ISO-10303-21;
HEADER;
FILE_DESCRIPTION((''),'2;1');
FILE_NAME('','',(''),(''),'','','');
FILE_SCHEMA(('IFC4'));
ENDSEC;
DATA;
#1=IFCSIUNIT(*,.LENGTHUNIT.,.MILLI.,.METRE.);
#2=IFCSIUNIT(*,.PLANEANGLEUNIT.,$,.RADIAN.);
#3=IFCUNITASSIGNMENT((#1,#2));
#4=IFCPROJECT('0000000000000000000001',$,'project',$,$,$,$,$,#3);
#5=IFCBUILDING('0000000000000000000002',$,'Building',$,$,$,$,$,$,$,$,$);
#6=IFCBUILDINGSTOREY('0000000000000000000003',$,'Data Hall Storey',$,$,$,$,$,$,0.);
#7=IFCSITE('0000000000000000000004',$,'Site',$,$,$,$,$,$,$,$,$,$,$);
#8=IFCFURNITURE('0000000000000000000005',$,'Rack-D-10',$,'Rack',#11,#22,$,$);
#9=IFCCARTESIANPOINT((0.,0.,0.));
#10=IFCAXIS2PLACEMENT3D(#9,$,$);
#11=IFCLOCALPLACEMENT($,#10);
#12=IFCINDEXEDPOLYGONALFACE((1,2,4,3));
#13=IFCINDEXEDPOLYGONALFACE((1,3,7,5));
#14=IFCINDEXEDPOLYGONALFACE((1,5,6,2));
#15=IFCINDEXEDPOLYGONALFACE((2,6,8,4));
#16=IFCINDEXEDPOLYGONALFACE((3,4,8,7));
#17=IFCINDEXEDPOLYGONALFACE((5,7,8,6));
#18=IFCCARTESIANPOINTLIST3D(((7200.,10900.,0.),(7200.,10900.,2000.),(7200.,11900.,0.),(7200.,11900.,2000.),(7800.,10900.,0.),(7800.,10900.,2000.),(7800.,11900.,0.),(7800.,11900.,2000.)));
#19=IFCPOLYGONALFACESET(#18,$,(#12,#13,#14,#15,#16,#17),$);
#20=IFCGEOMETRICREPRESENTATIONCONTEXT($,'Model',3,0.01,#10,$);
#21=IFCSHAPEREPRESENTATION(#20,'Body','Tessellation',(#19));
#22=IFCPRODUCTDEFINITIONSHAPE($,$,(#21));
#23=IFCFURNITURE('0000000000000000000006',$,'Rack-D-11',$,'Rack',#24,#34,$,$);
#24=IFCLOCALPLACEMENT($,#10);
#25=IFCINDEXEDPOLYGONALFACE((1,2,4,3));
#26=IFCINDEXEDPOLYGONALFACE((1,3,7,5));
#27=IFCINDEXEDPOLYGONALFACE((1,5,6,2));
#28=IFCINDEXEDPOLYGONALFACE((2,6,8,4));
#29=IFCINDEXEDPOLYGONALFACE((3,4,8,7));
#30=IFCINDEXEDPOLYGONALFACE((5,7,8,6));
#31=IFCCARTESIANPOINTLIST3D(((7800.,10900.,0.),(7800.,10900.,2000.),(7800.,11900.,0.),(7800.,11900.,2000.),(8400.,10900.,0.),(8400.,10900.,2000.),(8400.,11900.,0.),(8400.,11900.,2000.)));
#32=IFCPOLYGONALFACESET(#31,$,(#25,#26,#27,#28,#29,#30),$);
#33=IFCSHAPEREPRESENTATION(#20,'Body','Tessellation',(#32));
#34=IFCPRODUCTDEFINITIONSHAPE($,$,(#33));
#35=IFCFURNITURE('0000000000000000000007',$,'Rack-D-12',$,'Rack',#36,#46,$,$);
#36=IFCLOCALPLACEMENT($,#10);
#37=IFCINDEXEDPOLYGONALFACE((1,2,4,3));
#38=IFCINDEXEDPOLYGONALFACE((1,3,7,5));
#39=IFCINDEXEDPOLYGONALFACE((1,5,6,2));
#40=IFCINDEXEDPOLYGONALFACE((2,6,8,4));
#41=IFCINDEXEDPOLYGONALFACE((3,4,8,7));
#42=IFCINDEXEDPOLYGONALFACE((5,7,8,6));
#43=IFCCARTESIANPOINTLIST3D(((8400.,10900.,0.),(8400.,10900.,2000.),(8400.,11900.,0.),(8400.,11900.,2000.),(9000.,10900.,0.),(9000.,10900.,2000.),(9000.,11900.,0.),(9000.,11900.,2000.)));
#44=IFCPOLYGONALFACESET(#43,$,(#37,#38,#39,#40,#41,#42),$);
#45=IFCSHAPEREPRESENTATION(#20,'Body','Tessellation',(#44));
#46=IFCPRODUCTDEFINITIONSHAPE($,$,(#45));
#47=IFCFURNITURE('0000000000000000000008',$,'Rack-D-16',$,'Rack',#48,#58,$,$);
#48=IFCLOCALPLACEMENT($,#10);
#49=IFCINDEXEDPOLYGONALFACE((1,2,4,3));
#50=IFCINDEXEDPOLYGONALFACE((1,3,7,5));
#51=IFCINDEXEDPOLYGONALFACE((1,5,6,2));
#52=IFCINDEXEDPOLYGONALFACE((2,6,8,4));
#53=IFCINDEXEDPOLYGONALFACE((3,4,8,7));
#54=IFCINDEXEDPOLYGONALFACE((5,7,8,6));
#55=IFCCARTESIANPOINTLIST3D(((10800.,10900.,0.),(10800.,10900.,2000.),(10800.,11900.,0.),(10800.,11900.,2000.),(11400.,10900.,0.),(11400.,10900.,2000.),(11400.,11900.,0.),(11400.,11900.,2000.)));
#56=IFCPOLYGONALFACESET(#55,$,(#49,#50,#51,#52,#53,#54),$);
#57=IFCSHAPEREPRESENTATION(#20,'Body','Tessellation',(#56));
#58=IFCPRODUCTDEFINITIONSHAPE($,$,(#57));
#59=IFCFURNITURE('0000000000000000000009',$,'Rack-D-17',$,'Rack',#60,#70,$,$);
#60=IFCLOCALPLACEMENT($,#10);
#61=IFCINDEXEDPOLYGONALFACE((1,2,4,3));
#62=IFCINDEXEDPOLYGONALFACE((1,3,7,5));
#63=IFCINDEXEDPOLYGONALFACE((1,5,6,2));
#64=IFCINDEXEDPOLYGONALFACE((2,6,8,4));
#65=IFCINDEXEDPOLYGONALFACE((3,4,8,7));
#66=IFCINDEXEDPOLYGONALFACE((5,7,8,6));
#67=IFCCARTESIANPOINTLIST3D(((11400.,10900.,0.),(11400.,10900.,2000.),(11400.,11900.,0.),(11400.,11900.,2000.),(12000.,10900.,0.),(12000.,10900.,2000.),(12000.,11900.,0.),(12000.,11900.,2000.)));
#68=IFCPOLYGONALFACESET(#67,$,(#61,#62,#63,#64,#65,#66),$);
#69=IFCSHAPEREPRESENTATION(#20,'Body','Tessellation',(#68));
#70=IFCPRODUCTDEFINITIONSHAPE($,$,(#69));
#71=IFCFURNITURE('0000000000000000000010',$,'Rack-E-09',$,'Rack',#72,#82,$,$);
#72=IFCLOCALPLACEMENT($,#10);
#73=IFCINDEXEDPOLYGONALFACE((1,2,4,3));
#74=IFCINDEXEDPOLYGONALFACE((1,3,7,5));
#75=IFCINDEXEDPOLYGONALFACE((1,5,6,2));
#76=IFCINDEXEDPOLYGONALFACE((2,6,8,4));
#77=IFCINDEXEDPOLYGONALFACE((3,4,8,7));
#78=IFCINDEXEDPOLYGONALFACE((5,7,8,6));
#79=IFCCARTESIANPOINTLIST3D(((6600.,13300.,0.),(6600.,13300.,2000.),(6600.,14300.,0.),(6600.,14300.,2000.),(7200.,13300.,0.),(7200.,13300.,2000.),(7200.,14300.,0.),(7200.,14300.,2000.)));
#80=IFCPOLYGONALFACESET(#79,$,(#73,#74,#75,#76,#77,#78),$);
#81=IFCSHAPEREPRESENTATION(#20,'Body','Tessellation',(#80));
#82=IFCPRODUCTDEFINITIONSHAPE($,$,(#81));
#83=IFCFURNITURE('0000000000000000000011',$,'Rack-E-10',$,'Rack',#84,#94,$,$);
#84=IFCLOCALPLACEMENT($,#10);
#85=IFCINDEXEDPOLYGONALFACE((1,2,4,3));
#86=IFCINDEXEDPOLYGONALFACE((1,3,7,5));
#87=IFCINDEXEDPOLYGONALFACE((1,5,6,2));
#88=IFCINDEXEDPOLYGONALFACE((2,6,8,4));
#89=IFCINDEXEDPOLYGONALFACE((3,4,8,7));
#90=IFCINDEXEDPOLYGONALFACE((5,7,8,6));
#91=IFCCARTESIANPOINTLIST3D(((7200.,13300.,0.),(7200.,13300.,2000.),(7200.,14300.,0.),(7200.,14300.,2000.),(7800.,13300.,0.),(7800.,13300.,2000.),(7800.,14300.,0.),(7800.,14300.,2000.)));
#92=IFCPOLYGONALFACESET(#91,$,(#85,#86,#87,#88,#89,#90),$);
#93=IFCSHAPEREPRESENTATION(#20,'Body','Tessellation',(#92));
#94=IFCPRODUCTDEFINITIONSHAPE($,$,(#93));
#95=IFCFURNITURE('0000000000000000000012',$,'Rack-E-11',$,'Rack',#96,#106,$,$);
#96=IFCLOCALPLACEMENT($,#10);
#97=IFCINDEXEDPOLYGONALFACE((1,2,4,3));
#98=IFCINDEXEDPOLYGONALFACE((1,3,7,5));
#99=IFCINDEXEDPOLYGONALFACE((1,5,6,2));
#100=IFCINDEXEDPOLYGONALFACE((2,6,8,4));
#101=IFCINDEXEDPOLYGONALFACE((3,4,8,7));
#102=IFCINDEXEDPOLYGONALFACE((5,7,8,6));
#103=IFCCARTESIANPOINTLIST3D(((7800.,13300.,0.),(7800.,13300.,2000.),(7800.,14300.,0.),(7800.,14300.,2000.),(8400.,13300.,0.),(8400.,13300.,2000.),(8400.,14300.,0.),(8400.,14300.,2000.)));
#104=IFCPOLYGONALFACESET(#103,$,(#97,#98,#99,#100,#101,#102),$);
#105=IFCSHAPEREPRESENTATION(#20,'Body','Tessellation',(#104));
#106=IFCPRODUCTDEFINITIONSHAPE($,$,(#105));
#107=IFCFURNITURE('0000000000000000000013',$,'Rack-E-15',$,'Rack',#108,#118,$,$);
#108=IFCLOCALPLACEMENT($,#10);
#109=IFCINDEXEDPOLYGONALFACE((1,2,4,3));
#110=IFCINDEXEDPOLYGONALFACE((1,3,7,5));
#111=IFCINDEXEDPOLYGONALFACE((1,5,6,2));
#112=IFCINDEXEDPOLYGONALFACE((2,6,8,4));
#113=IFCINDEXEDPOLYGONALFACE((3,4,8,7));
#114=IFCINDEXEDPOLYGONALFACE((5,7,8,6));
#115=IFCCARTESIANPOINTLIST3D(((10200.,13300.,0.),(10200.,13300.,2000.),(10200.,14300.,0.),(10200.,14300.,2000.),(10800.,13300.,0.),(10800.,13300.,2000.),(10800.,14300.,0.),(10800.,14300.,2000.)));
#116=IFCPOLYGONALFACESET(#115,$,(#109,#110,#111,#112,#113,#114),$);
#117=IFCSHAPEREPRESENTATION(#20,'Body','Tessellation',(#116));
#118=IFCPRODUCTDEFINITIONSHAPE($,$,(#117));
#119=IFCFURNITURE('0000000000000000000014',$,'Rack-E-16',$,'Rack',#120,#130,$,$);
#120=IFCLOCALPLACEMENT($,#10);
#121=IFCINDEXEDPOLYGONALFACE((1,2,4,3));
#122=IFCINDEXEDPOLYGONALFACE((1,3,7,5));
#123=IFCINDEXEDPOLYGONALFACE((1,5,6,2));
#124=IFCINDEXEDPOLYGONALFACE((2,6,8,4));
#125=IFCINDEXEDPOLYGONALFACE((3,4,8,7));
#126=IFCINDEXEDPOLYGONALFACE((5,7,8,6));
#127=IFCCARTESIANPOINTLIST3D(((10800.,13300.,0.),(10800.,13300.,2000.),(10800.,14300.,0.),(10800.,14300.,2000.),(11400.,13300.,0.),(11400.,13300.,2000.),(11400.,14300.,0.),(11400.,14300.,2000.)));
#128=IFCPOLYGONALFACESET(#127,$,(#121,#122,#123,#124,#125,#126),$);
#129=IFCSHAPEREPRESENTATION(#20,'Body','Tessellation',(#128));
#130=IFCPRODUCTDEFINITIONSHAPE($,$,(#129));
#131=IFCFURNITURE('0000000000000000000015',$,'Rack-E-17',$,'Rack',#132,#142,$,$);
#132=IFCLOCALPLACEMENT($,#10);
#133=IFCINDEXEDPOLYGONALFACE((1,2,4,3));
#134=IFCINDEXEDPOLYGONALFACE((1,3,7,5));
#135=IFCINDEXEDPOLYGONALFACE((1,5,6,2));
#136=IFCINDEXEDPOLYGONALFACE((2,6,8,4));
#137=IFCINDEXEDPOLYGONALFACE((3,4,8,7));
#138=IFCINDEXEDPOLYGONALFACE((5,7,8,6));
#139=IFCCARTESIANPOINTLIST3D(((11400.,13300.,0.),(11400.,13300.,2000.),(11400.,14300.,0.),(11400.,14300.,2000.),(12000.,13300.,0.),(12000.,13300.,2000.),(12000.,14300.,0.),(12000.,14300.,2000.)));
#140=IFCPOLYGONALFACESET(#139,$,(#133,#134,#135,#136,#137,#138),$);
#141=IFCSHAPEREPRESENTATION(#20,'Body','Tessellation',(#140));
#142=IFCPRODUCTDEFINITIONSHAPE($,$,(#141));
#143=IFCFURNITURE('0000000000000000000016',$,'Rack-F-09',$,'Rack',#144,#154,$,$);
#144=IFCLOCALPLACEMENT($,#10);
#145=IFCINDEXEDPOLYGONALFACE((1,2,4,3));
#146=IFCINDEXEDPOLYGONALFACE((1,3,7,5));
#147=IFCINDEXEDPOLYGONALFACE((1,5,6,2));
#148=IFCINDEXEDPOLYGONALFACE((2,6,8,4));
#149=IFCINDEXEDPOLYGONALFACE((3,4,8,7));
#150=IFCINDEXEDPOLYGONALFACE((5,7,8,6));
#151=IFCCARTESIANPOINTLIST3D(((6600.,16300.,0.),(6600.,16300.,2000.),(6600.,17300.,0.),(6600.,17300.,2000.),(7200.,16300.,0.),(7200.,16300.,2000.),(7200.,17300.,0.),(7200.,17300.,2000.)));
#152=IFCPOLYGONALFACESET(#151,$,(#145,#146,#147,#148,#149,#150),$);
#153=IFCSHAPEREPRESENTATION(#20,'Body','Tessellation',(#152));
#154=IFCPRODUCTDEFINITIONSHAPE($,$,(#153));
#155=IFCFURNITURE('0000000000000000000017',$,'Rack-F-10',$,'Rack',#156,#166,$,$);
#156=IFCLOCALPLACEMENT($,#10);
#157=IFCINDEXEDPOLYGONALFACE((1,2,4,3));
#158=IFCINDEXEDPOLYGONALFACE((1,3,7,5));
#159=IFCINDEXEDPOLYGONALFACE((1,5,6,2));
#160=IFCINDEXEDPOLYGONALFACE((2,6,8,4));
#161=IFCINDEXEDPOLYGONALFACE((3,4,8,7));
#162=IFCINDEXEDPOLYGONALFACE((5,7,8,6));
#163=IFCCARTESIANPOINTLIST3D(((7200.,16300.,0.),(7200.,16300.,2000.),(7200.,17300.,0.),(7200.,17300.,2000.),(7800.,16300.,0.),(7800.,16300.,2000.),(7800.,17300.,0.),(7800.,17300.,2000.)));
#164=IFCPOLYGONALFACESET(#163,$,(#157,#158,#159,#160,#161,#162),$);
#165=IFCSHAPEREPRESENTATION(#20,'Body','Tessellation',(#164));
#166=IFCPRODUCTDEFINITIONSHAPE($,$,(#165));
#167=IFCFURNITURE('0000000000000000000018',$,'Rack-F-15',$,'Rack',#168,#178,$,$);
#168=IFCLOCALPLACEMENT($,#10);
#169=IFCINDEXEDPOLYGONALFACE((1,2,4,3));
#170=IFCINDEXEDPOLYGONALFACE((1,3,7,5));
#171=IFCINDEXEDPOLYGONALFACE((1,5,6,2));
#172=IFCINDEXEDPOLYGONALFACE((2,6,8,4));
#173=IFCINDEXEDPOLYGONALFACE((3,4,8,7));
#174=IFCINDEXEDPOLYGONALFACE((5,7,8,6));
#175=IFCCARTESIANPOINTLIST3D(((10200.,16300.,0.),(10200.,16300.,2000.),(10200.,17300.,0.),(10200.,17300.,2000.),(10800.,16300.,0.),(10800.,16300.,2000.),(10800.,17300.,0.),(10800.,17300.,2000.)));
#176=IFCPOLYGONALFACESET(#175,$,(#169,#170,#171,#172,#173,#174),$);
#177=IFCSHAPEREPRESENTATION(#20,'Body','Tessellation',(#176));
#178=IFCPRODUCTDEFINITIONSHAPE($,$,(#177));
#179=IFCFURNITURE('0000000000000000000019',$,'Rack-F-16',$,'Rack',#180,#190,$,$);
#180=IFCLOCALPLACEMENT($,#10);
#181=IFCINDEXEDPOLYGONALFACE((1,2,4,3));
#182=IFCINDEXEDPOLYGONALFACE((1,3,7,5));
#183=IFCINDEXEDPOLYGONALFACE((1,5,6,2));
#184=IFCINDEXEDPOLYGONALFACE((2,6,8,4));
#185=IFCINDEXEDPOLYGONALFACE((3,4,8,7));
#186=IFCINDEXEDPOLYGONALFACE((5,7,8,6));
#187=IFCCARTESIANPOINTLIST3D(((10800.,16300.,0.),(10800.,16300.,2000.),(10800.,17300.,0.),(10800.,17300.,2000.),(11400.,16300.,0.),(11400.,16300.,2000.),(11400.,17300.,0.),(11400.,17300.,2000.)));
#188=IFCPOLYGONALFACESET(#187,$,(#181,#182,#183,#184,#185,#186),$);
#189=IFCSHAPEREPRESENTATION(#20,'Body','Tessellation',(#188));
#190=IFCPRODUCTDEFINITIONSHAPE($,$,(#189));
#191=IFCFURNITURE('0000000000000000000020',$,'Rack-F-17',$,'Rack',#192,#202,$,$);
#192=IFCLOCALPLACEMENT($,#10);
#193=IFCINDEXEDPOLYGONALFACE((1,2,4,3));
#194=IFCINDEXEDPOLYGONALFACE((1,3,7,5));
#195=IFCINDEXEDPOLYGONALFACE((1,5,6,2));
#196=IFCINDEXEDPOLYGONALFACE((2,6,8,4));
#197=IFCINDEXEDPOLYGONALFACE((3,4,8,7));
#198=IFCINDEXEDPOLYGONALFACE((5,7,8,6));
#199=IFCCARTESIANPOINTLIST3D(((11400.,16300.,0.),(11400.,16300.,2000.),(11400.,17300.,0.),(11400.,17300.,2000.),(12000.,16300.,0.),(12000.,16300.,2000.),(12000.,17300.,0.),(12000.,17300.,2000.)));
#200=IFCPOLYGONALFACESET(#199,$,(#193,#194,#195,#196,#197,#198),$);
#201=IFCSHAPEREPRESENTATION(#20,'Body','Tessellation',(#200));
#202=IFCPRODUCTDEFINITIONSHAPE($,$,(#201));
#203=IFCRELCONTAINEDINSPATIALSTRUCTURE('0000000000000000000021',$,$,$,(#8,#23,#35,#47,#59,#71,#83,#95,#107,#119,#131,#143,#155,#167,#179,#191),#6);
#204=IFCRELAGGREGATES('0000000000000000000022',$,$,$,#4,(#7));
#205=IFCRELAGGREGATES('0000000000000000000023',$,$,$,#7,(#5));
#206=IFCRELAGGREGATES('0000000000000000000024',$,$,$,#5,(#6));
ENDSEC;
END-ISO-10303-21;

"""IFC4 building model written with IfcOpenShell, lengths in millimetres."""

from ifc_helpers import new_model, si_unit, frame, origin, place, context, project, spatial, rectangle, extrude, element, save


model = new_model("IFC4")

# Units and contexts
model_context = context("Model", 3, precision=0.01, world=origin())
ifc_project = project(units=[si_unit("LENGTHUNIT", "METRE", prefix="MILLI"), si_unit("PLANEANGLEUNIT", "RADIAN")])

# Site, building, storey
site = spatial("IfcSite", under=ifc_project, Name="Site")
building = spatial("IfcBuilding", under=site, Name="Building")
storey = spatial("IfcBuildingStorey", under=building, Name="Data Hall Storey", Elevation=0.0)

# Furniture
for number, where, name in (
    (1, (7500.0, 11400.0, 0.0), "Rack-D-10"),
    (2, (8100.0, 11400.0, 0.0), "Rack-D-11"),
    (3, (8700.0, 11400.0, 0.0), "Rack-D-12"),
    (4, (11100.0, 11400.0, 0.0), "Rack-D-16"),
    (5, (11700.0, 11400.0, 0.0), "Rack-D-17"),
    (6, (6900.0, 13800.0, 0.0), "Rack-E-09"),
    (7, (7500.0, 13800.0, 0.0), "Rack-E-10"),
    (8, (8100.0, 13800.0, 0.0), "Rack-E-11"),
    (9, (10500.0, 13800.0, 0.0), "Rack-E-15"),
    (10, (11100.0, 13800.0, 0.0), "Rack-E-16"),
    (11, (11700.0, 13800.0, 0.0), "Rack-E-17"),
    (12, (6900.0, 16800.0, 0.0), "Rack-F-09"),
    (13, (7500.0, 16800.0, 0.0), "Rack-F-10"),
    (14, (10500.0, 16800.0, 0.0), "Rack-F-15"),
    (15, (11100.0, 16800.0, 0.0), "Rack-F-16"),
    (16, (11700.0, 16800.0, 0.0), "Rack-F-17"),
):
    element("IfcFurniture", number, at=place(None, frame(where)), inside=storey, Name=name, ObjectType="Rack", context=model_context, shape_type="SweptSolid", body=[
        extrude(rectangle(XDim=600.0, YDim=1000.0), origin(), (0.0, 0.0, 1.0), 2000.0),
    ])

save(model, "model.ifc")
